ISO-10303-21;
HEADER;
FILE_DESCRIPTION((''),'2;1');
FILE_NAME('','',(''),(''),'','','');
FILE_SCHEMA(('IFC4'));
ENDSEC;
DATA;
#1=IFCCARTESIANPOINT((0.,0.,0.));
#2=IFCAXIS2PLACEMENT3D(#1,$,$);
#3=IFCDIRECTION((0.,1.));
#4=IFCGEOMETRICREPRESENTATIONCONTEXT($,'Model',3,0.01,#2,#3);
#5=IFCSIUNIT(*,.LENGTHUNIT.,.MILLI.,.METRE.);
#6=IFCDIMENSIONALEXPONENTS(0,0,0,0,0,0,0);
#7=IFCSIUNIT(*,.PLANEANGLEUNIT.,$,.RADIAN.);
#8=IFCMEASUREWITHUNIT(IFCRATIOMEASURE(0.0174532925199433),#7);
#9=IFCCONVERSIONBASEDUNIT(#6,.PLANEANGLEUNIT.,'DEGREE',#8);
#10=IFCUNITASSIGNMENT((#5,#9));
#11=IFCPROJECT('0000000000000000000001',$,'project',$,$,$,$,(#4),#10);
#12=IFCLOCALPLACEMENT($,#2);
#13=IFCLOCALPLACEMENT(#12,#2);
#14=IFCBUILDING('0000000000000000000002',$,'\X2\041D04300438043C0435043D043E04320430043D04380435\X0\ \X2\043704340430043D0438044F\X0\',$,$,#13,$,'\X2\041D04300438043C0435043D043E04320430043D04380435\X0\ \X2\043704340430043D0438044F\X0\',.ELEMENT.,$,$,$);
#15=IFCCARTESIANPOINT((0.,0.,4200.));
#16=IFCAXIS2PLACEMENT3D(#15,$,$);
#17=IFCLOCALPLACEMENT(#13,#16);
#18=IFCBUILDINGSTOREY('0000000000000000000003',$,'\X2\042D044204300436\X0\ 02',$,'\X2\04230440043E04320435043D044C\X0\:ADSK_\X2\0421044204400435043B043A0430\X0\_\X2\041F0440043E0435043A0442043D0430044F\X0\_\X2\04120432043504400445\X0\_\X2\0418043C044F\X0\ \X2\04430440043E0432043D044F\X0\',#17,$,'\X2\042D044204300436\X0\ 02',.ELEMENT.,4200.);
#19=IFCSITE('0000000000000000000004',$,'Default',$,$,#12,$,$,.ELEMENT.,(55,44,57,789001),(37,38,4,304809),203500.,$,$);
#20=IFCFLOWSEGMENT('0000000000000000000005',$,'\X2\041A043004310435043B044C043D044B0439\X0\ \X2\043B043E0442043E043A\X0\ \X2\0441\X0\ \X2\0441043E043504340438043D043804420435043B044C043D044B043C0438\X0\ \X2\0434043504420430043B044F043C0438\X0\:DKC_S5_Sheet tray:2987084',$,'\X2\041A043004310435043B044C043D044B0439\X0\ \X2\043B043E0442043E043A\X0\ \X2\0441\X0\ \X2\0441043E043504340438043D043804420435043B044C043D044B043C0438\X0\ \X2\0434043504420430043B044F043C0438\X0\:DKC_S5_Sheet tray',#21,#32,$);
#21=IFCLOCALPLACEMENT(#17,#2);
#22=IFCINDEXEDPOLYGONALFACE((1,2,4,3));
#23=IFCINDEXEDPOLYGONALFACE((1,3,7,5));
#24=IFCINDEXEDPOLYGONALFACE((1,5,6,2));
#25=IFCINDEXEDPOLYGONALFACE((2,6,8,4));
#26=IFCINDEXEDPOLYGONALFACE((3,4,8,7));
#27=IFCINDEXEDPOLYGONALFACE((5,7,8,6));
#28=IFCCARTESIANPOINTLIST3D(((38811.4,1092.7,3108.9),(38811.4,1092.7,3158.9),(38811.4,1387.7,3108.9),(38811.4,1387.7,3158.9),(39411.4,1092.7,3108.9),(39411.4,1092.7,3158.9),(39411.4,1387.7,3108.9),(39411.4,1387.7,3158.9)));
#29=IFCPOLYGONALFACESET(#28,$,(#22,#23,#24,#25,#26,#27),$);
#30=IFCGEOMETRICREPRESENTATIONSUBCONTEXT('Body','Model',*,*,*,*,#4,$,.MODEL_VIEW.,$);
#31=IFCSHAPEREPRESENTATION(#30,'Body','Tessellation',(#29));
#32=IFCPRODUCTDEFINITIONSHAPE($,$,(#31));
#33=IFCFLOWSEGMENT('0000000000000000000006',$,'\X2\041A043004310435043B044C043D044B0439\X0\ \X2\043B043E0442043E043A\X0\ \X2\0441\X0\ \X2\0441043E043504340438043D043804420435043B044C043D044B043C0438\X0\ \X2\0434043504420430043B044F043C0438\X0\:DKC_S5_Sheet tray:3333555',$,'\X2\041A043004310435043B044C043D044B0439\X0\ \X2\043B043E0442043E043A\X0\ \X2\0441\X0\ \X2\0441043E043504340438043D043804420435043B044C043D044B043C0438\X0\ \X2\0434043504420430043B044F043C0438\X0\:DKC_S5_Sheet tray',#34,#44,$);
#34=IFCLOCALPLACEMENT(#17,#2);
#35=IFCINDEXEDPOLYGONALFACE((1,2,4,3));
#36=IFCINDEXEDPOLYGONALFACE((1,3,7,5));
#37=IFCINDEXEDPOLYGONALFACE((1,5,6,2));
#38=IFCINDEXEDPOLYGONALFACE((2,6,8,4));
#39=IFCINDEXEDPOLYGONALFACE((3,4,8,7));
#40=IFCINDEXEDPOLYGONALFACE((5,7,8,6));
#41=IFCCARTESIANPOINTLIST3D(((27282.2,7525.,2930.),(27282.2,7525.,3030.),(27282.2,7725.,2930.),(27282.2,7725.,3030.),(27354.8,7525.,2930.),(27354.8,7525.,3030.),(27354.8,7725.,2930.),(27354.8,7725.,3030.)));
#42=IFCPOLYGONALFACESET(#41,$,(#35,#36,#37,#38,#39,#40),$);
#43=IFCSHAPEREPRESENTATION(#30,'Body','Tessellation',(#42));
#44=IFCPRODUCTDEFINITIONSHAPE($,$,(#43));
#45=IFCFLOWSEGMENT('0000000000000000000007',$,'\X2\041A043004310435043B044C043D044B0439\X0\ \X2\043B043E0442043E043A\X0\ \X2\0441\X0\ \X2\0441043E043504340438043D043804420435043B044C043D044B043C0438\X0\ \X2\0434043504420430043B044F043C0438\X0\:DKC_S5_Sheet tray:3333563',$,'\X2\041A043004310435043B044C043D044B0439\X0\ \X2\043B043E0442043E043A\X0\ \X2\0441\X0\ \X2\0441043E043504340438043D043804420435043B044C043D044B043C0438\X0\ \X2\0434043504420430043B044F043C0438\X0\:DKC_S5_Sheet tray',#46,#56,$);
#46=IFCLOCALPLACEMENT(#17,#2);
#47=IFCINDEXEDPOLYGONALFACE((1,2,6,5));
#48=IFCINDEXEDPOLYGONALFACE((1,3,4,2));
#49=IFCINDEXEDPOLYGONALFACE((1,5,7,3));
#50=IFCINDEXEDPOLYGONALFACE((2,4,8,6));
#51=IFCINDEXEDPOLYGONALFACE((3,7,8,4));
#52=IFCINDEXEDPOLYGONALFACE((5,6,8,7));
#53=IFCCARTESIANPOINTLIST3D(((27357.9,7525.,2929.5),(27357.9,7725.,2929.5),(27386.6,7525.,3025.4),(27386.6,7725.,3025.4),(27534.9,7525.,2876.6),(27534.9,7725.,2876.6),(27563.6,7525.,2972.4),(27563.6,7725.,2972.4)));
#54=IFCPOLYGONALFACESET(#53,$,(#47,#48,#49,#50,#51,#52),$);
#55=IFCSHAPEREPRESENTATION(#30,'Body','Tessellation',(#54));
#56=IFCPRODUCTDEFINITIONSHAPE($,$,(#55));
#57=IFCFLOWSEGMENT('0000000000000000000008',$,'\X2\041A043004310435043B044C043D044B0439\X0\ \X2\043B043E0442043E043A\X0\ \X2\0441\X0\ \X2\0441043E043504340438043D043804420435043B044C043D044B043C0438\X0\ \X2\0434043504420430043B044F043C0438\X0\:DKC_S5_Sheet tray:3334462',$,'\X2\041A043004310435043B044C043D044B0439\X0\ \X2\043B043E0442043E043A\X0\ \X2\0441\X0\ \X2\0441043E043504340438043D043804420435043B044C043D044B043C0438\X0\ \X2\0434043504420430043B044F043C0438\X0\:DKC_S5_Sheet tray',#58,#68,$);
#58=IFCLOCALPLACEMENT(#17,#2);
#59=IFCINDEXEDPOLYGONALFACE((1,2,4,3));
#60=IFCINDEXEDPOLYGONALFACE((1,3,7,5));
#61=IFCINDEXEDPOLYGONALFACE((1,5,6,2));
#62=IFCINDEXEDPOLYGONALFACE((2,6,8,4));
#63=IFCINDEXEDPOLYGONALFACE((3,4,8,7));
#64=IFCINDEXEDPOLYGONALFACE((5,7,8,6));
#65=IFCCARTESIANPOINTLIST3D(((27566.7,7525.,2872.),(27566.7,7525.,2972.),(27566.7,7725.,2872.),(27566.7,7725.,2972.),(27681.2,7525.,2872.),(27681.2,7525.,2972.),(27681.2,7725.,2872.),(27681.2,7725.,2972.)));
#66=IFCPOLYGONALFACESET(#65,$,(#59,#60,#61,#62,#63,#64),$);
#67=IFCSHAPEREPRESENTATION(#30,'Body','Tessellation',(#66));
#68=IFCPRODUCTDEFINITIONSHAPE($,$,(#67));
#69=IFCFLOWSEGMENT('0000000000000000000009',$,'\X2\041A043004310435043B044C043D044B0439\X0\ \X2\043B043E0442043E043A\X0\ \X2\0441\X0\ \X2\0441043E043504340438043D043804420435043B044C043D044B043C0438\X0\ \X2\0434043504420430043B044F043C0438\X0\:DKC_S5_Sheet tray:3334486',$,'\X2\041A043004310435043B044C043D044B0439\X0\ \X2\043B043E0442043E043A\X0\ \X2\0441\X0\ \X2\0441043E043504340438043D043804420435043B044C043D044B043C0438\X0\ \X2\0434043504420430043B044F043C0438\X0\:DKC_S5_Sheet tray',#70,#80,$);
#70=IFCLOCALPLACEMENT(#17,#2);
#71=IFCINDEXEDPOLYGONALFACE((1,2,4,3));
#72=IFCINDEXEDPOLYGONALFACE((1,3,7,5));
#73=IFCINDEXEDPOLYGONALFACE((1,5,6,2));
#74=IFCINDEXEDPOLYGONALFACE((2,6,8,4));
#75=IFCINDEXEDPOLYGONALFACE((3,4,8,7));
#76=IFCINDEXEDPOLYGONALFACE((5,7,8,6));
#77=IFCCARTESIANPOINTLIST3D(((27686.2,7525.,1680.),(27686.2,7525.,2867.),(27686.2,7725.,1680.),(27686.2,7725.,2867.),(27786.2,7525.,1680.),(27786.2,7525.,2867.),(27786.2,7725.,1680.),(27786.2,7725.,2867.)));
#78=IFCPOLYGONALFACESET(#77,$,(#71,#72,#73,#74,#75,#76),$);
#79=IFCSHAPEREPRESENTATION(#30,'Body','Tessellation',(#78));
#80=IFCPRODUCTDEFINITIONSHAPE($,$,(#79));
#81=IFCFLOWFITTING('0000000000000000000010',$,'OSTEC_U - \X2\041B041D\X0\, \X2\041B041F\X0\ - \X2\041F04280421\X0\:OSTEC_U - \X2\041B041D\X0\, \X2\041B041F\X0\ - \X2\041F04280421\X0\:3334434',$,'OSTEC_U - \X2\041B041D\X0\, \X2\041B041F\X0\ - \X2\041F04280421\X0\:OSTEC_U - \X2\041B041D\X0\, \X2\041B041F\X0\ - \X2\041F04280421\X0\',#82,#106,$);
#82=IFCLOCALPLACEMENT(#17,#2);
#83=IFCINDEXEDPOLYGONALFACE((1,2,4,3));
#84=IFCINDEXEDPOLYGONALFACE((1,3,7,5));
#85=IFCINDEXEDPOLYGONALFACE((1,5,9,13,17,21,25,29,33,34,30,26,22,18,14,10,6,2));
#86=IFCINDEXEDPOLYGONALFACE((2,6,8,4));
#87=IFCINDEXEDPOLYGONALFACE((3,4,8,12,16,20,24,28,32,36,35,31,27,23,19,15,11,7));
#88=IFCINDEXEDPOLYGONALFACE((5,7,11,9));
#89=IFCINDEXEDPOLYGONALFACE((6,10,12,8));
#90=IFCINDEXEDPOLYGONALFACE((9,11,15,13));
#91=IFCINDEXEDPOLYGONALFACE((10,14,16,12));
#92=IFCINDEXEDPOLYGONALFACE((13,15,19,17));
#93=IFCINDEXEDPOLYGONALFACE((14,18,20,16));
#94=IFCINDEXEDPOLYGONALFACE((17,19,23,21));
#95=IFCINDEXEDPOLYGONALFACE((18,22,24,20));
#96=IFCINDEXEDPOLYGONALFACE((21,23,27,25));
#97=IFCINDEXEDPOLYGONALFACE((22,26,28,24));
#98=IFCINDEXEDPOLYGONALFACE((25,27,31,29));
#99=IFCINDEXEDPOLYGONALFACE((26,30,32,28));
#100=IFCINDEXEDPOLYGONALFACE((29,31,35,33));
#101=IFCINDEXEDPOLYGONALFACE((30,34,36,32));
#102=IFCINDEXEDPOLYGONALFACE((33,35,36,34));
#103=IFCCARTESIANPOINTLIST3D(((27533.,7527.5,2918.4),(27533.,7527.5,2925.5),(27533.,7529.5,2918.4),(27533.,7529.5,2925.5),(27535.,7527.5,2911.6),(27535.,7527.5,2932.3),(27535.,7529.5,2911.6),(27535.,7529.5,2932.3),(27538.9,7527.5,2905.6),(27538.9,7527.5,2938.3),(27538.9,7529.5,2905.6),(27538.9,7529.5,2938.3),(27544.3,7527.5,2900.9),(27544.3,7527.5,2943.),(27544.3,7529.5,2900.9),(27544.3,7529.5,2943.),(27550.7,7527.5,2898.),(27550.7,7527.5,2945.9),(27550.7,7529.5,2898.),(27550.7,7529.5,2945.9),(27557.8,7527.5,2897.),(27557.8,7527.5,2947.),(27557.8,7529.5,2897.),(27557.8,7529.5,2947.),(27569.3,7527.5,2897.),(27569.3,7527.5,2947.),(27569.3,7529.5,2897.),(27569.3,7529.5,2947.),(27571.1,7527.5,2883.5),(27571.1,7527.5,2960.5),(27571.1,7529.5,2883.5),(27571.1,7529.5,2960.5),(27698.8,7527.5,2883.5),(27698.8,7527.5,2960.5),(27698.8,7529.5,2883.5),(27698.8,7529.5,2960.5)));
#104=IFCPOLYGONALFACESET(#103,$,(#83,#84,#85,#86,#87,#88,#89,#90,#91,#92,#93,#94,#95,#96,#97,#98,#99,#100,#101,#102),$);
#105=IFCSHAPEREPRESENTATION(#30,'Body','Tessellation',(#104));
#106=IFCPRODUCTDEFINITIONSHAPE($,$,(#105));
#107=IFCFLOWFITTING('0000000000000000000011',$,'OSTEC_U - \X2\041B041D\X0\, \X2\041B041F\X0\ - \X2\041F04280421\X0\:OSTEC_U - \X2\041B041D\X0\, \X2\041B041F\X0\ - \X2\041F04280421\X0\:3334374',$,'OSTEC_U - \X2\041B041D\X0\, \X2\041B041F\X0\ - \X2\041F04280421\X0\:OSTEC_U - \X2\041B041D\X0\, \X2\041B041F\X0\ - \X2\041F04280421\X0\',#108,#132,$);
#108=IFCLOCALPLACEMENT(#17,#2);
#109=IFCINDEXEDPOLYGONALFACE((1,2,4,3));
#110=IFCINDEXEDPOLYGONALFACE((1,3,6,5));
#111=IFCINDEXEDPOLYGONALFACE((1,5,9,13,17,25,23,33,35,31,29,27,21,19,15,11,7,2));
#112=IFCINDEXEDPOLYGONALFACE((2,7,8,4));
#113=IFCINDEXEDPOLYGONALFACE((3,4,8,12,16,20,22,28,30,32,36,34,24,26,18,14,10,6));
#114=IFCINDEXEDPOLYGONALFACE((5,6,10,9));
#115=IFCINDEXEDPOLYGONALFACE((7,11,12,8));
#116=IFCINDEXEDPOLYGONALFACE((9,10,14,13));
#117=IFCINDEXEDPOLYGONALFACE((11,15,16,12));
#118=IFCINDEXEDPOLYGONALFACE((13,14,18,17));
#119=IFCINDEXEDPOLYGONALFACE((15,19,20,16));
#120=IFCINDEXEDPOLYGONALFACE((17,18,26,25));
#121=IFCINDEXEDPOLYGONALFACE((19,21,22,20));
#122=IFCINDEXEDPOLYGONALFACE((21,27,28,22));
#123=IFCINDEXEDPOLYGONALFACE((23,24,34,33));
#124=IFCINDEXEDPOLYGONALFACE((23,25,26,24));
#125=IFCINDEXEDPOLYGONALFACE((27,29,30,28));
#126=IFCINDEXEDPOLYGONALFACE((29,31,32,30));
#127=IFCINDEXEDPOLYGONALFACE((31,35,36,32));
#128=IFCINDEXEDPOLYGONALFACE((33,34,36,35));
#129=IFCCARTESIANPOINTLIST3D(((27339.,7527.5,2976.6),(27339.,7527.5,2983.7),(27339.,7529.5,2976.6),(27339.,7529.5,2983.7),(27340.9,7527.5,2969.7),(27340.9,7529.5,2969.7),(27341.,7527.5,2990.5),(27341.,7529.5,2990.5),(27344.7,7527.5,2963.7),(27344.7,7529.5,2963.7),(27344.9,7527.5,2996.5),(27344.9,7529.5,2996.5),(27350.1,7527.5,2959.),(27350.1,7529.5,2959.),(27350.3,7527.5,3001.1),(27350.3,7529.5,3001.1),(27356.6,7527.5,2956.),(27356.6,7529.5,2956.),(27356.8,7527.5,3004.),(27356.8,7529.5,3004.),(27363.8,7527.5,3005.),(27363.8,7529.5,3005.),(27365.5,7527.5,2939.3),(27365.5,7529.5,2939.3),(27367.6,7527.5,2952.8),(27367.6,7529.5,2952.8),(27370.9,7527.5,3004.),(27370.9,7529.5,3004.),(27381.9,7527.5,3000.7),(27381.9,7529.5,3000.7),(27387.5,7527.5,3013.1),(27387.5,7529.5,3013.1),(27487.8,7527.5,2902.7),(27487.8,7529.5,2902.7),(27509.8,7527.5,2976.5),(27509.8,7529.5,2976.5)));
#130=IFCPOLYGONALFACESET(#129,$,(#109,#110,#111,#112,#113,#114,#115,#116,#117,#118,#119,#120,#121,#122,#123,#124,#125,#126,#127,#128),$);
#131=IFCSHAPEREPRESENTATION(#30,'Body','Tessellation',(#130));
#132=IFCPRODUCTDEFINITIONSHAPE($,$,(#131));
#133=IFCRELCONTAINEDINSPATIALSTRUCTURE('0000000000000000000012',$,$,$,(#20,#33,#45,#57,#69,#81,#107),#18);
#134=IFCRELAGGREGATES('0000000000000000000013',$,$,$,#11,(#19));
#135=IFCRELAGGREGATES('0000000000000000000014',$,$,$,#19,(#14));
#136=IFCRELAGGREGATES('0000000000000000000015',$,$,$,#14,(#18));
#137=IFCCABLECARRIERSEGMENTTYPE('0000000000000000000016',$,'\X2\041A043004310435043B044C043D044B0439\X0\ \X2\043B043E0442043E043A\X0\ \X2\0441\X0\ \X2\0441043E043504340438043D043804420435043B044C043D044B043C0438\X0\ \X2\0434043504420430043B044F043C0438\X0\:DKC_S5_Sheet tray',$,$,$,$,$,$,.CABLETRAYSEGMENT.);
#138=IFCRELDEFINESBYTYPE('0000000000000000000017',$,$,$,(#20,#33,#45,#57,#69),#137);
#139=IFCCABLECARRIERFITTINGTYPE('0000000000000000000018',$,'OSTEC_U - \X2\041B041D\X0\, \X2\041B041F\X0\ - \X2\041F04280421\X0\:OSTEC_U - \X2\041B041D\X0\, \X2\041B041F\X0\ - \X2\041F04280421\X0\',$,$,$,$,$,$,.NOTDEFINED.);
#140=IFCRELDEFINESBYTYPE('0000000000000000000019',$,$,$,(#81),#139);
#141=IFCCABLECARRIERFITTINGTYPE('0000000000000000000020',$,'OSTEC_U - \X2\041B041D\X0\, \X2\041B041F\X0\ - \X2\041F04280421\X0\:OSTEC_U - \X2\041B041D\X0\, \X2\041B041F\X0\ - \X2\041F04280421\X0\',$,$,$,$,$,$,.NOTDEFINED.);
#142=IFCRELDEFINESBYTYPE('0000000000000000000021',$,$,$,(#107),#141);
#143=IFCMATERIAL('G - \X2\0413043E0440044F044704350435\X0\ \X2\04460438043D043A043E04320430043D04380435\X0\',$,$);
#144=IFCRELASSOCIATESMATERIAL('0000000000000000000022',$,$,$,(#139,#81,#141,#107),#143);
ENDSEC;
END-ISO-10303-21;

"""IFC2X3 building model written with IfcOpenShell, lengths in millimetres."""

from ifc_helpers import new_model, entity, si_unit, converted_unit, direction, frame, frame_2d, origin, origin_2d_with_axis, place, context, subcontext, project, spatial, polyline, circle_curve, parameter, trimmed, segment, composite_curve, rectangle, outline, extrude, source, transform, mapped, material, type_object, type_shapes, element, save


model = new_model("IFC2X3")

# Units and contexts
model_context = context("Model", 3, precision=0.01, world=origin(), true_north=direction((0.0, 1.0)))
body_context = subcontext(model_context, "Body", "Model", "MODEL_VIEW")
ifc_project = project(units=[si_unit("LENGTHUNIT", "METRE", prefix="MILLI"), converted_unit("PLANEANGLEUNIT", "DEGREE", entity("IfcRatioMeasure", 0.0174532925199433), si_unit("PLANEANGLEUNIT", "RADIAN"), dimensions=[0, 0, 0, 0, 0, 0, 0])], contexts=[model_context])

# Site, building, storey
site_placement = place(None, frame((0.0, 0.0, 0.0)))
site = spatial("IfcSite", under=ifc_project, at=site_placement, Name="Default", CompositionType="ELEMENT", RefLatitude=(55, 44, 57, 789001), RefLongitude=(37, 38, 4, 304809), RefElevation=203500.0)
building_placement = place(site_placement, origin())
building = spatial("IfcBuilding", under=site, at=building_placement, Name="Наименование здания", LongName="Наименование здания", CompositionType="ELEMENT")
storey_placement = place(building_placement, frame((0.0, 0.0, 4200.0)))
storey = spatial("IfcBuildingStorey", under=building, at=storey_placement, Name="Этаж 02", ObjectType="Уровень:ADSK_Стрелка_Проектная_Вверх_Имя уровня", LongName="Этаж 02", CompositionType="ELEMENT", Elevation=4200.0)

# Flow segments
cable_carrier_segment_type = type_object("IfcCableCarrierSegmentType", Name="Кабельный лоток с соединительными деталями:DKC_S5_Sheet tray", PredefinedType="CABLETRAYSEGMENT")
flow_segment_1_placement = place(storey_placement, frame((38811.4, 1092.7, 3108.9)))
element("IfcFlowSegment", 1, at=flow_segment_1_placement, inside=storey, type_object=cable_carrier_segment_type, Name="Кабельный лоток с соединительными деталями:DKC_S5_Sheet tray:2987084", ObjectType="Кабельный лоток с соединительными деталями:DKC_S5_Sheet tray", context=body_context, shape_type="SweptSolid", body=[
    extrude(rectangle(XDim=295.1, YDim=600.0, at=frame_2d((0.0, 0.0), x_axis=(1.0, 0.0))), frame((300.0, 147.5, 0.0), z_axis=(0.0, 0.0, 1.0), x_axis=(0.0, 1.0, 0.0)), (0.0, 0.0, 1.0), 50.0),
])
flow_segment_2_placement = place(storey_placement, frame((27282.2, 7525.0, 2930.0)))
element("IfcFlowSegment", 2, at=flow_segment_2_placement, inside=storey, type_object=cable_carrier_segment_type, Name="Кабельный лоток с соединительными деталями:DKC_S5_Sheet tray:3333555", ObjectType="Кабельный лоток с соединительными деталями:DKC_S5_Sheet tray", context=body_context, shape_type="SweptSolid", body=[
    extrude(rectangle(XDim=72.6, YDim=200.0, at=frame_2d((0.0, 0.0), x_axis=(1.0, 0.0))), frame((36.3, 100.0, 0.0)), (0.0, 0.0, 1.0), 100.0),
])
flow_segment_3_placement = place(storey_placement, frame((27357.9, 7525.0, 2876.6)))
element("IfcFlowSegment", 3, at=flow_segment_3_placement, inside=storey, type_object=cable_carrier_segment_type, Name="Кабельный лоток с соединительными деталями:DKC_S5_Sheet tray:3333563", ObjectType="Кабельный лоток с соединительными деталями:DKC_S5_Sheet tray", context=body_context, shape_type="SweptSolid", body=[
    extrude(rectangle(XDim=100.0, YDim=184.8, at=frame_2d((0.0, 0.0), x_axis=(0.0, 1.0))), frame((102.8, 0.0, 74.4), z_axis=(0.0, 1.0, 0.0), x_axis=(0.958072, 0.0, -0.286526)), (0.0, 0.0, 1.0), 200.0),
])
flow_segment_4_placement = place(storey_placement, frame((27566.7, 7525.0, 2872.0)))
element("IfcFlowSegment", 4, at=flow_segment_4_placement, inside=storey, type_object=cable_carrier_segment_type, Name="Кабельный лоток с соединительными деталями:DKC_S5_Sheet tray:3334462", ObjectType="Кабельный лоток с соединительными деталями:DKC_S5_Sheet tray", context=body_context, shape_type="SweptSolid", body=[
    extrude(rectangle(XDim=114.5, YDim=200.0, at=frame_2d((0.0, 0.0), x_axis=(1.0, 0.0))), frame((57.3, 100.0, 0.0)), (0.0, 0.0, 1.0), 100.0),
])
flow_segment_5_placement = place(storey_placement, frame((27686.2, 7525.0, 1680.0)))
element("IfcFlowSegment", 5, at=flow_segment_5_placement, inside=storey, type_object=cable_carrier_segment_type, Name="Кабельный лоток с соединительными деталями:DKC_S5_Sheet tray:3334486", ObjectType="Кабельный лоток с соединительными деталями:DKC_S5_Sheet tray", context=body_context, shape_type="SweptSolid", body=[
    extrude(rectangle(XDim=100.0, YDim=200.0, at=origin_2d_with_axis()), frame((50.0, 100.0, 0.0)), (0.0, 0.0, 1.0), 1187.0),
])

# Flow fittings
ifc_material_1 = material(Name="G - Горячее цинкование")
cable_carrier_fitting_type_1 = type_object("IfcCableCarrierFittingType", Name="OSTEC_U - ЛН, ЛП - ПШС:OSTEC_U - ЛН, ЛП - ПШС", PredefinedType="NOTDEFINED", material=ifc_material_1)
shared_shape_1 = source(origin(), body_context, "Body", "SweptSolid", [
    extrude(outline(composite_curve([segment(trimmed(circle_curve(frame_2d((-41.5, 0.0), x_axis=(1.0, 0.0)), 25.0), [parameter(90.0)], [parameter(270.0)], True, "PARAMETER"), True, "CONTINUOUS"), segment(polyline([(-41.5, -25.0), (-30.0, -25.0)]), True, "CONTINUOUS"), segment(polyline([(-30.0, -25.0), (-28.1, -38.5)]), True, "CONTINUOUS"), segment(polyline([(-28.1, -38.5), (99.5, -38.5)]), True, "CONTINUOUS"), segment(polyline([(99.5, -38.5), (99.5, 38.5)]), True, "CONTINUOUS"), segment(polyline([(99.5, 38.5), (-28.1, 38.5)]), True, "CONTINUOUS"), segment(polyline([(-28.1, 38.5), (-30.0, 25.0)]), True, "CONTINUOUS"), segment(polyline([(-30.0, 25.0), (-41.5, 25.0)]), True, "CONTINUOUS")], self_intersect=False)), frame((41.5, 0.0, 0.0), z_axis=(0.0, 0.0, -1.0), x_axis=(1.0, 0.0, 0.0)), (0.0, 0.0, -1.0), 2.0),
])
type_shapes(cable_carrier_fitting_type_1, [shared_shape_1])
flow_fitting_1_placement = place(storey_placement, frame((27557.8, 7529.5, 2922.0), z_axis=(0.0, -1.0, 0.0), x_axis=(1.0, 0.0, 0.0)))
element("IfcFlowFitting", 6, at=flow_fitting_1_placement, inside=storey, type_object=cable_carrier_fitting_type_1, material=ifc_material_1, Name="OSTEC_U - ЛН, ЛП - ПШС:OSTEC_U - ЛН, ЛП - ПШС:3334434", ObjectType="OSTEC_U - ЛН, ЛП - ПШС:OSTEC_U - ЛН, ЛП - ПШС", context=body_context, shape_type="MappedRepresentation", body=[
    mapped(shared_shape_1, transform((0.0, 0.0, 0.0), scale=1.0)),
])
cable_carrier_fitting_type_2 = type_object("IfcCableCarrierFittingType", Name="OSTEC_U - ЛН, ЛП - ПШС:OSTEC_U - ЛН, ЛП - ПШС", PredefinedType="NOTDEFINED", material=ifc_material_1)
shared_shape_2 = source(origin(), body_context, "Body", "SweptSolid", [
    extrude(outline(composite_curve([segment(trimmed(circle_curve(frame_2d((-41.5, 0.0), x_axis=(1.0, 0.0)), 25.0), [parameter(90.0)], [parameter(270.0)], True, "PARAMETER"), True, "CONTINUOUS"), segment(polyline([(-41.5, -25.0), (-30.0, -25.0)]), True, "CONTINUOUS"), segment(polyline([(-30.0, -25.0), (-28.1, -38.5)]), True, "CONTINUOUS"), segment(polyline([(-28.1, -38.5), (99.5, -38.5)]), True, "CONTINUOUS"), segment(polyline([(99.5, -38.5), (99.5, 38.5)]), True, "CONTINUOUS"), segment(polyline([(99.5, 38.5), (-28.1, 38.5)]), True, "CONTINUOUS"), segment(polyline([(-28.1, 38.5), (-30.0, 25.0)]), True, "CONTINUOUS"), segment(polyline([(-30.0, 25.0), (-41.5, 25.0)]), True, "CONTINUOUS")], self_intersect=False)), frame((41.5, 0.0, 0.0)), (0.0, 0.0, 1.0), 2.0),
])
type_shapes(cable_carrier_fitting_type_2, [shared_shape_2])
flow_fitting_2_placement = place(storey_placement, frame((27363.7, 7529.5, 2980.0), z_axis=(0.0, -1.0, 0.0), x_axis=(0.958072, 0.0, -0.286526)))
element("IfcFlowFitting", 7, at=flow_fitting_2_placement, inside=storey, type_object=cable_carrier_fitting_type_2, material=ifc_material_1, Name="OSTEC_U - ЛН, ЛП - ПШС:OSTEC_U - ЛН, ЛП - ПШС:3334374", ObjectType="OSTEC_U - ЛН, ЛП - ПШС:OSTEC_U - ЛН, ЛП - ПШС", context=body_context, shape_type="MappedRepresentation", body=[
    mapped(shared_shape_2, transform((0.0, 0.0, 0.0), scale=1.0)),
])

save(model, "model.ifc")
